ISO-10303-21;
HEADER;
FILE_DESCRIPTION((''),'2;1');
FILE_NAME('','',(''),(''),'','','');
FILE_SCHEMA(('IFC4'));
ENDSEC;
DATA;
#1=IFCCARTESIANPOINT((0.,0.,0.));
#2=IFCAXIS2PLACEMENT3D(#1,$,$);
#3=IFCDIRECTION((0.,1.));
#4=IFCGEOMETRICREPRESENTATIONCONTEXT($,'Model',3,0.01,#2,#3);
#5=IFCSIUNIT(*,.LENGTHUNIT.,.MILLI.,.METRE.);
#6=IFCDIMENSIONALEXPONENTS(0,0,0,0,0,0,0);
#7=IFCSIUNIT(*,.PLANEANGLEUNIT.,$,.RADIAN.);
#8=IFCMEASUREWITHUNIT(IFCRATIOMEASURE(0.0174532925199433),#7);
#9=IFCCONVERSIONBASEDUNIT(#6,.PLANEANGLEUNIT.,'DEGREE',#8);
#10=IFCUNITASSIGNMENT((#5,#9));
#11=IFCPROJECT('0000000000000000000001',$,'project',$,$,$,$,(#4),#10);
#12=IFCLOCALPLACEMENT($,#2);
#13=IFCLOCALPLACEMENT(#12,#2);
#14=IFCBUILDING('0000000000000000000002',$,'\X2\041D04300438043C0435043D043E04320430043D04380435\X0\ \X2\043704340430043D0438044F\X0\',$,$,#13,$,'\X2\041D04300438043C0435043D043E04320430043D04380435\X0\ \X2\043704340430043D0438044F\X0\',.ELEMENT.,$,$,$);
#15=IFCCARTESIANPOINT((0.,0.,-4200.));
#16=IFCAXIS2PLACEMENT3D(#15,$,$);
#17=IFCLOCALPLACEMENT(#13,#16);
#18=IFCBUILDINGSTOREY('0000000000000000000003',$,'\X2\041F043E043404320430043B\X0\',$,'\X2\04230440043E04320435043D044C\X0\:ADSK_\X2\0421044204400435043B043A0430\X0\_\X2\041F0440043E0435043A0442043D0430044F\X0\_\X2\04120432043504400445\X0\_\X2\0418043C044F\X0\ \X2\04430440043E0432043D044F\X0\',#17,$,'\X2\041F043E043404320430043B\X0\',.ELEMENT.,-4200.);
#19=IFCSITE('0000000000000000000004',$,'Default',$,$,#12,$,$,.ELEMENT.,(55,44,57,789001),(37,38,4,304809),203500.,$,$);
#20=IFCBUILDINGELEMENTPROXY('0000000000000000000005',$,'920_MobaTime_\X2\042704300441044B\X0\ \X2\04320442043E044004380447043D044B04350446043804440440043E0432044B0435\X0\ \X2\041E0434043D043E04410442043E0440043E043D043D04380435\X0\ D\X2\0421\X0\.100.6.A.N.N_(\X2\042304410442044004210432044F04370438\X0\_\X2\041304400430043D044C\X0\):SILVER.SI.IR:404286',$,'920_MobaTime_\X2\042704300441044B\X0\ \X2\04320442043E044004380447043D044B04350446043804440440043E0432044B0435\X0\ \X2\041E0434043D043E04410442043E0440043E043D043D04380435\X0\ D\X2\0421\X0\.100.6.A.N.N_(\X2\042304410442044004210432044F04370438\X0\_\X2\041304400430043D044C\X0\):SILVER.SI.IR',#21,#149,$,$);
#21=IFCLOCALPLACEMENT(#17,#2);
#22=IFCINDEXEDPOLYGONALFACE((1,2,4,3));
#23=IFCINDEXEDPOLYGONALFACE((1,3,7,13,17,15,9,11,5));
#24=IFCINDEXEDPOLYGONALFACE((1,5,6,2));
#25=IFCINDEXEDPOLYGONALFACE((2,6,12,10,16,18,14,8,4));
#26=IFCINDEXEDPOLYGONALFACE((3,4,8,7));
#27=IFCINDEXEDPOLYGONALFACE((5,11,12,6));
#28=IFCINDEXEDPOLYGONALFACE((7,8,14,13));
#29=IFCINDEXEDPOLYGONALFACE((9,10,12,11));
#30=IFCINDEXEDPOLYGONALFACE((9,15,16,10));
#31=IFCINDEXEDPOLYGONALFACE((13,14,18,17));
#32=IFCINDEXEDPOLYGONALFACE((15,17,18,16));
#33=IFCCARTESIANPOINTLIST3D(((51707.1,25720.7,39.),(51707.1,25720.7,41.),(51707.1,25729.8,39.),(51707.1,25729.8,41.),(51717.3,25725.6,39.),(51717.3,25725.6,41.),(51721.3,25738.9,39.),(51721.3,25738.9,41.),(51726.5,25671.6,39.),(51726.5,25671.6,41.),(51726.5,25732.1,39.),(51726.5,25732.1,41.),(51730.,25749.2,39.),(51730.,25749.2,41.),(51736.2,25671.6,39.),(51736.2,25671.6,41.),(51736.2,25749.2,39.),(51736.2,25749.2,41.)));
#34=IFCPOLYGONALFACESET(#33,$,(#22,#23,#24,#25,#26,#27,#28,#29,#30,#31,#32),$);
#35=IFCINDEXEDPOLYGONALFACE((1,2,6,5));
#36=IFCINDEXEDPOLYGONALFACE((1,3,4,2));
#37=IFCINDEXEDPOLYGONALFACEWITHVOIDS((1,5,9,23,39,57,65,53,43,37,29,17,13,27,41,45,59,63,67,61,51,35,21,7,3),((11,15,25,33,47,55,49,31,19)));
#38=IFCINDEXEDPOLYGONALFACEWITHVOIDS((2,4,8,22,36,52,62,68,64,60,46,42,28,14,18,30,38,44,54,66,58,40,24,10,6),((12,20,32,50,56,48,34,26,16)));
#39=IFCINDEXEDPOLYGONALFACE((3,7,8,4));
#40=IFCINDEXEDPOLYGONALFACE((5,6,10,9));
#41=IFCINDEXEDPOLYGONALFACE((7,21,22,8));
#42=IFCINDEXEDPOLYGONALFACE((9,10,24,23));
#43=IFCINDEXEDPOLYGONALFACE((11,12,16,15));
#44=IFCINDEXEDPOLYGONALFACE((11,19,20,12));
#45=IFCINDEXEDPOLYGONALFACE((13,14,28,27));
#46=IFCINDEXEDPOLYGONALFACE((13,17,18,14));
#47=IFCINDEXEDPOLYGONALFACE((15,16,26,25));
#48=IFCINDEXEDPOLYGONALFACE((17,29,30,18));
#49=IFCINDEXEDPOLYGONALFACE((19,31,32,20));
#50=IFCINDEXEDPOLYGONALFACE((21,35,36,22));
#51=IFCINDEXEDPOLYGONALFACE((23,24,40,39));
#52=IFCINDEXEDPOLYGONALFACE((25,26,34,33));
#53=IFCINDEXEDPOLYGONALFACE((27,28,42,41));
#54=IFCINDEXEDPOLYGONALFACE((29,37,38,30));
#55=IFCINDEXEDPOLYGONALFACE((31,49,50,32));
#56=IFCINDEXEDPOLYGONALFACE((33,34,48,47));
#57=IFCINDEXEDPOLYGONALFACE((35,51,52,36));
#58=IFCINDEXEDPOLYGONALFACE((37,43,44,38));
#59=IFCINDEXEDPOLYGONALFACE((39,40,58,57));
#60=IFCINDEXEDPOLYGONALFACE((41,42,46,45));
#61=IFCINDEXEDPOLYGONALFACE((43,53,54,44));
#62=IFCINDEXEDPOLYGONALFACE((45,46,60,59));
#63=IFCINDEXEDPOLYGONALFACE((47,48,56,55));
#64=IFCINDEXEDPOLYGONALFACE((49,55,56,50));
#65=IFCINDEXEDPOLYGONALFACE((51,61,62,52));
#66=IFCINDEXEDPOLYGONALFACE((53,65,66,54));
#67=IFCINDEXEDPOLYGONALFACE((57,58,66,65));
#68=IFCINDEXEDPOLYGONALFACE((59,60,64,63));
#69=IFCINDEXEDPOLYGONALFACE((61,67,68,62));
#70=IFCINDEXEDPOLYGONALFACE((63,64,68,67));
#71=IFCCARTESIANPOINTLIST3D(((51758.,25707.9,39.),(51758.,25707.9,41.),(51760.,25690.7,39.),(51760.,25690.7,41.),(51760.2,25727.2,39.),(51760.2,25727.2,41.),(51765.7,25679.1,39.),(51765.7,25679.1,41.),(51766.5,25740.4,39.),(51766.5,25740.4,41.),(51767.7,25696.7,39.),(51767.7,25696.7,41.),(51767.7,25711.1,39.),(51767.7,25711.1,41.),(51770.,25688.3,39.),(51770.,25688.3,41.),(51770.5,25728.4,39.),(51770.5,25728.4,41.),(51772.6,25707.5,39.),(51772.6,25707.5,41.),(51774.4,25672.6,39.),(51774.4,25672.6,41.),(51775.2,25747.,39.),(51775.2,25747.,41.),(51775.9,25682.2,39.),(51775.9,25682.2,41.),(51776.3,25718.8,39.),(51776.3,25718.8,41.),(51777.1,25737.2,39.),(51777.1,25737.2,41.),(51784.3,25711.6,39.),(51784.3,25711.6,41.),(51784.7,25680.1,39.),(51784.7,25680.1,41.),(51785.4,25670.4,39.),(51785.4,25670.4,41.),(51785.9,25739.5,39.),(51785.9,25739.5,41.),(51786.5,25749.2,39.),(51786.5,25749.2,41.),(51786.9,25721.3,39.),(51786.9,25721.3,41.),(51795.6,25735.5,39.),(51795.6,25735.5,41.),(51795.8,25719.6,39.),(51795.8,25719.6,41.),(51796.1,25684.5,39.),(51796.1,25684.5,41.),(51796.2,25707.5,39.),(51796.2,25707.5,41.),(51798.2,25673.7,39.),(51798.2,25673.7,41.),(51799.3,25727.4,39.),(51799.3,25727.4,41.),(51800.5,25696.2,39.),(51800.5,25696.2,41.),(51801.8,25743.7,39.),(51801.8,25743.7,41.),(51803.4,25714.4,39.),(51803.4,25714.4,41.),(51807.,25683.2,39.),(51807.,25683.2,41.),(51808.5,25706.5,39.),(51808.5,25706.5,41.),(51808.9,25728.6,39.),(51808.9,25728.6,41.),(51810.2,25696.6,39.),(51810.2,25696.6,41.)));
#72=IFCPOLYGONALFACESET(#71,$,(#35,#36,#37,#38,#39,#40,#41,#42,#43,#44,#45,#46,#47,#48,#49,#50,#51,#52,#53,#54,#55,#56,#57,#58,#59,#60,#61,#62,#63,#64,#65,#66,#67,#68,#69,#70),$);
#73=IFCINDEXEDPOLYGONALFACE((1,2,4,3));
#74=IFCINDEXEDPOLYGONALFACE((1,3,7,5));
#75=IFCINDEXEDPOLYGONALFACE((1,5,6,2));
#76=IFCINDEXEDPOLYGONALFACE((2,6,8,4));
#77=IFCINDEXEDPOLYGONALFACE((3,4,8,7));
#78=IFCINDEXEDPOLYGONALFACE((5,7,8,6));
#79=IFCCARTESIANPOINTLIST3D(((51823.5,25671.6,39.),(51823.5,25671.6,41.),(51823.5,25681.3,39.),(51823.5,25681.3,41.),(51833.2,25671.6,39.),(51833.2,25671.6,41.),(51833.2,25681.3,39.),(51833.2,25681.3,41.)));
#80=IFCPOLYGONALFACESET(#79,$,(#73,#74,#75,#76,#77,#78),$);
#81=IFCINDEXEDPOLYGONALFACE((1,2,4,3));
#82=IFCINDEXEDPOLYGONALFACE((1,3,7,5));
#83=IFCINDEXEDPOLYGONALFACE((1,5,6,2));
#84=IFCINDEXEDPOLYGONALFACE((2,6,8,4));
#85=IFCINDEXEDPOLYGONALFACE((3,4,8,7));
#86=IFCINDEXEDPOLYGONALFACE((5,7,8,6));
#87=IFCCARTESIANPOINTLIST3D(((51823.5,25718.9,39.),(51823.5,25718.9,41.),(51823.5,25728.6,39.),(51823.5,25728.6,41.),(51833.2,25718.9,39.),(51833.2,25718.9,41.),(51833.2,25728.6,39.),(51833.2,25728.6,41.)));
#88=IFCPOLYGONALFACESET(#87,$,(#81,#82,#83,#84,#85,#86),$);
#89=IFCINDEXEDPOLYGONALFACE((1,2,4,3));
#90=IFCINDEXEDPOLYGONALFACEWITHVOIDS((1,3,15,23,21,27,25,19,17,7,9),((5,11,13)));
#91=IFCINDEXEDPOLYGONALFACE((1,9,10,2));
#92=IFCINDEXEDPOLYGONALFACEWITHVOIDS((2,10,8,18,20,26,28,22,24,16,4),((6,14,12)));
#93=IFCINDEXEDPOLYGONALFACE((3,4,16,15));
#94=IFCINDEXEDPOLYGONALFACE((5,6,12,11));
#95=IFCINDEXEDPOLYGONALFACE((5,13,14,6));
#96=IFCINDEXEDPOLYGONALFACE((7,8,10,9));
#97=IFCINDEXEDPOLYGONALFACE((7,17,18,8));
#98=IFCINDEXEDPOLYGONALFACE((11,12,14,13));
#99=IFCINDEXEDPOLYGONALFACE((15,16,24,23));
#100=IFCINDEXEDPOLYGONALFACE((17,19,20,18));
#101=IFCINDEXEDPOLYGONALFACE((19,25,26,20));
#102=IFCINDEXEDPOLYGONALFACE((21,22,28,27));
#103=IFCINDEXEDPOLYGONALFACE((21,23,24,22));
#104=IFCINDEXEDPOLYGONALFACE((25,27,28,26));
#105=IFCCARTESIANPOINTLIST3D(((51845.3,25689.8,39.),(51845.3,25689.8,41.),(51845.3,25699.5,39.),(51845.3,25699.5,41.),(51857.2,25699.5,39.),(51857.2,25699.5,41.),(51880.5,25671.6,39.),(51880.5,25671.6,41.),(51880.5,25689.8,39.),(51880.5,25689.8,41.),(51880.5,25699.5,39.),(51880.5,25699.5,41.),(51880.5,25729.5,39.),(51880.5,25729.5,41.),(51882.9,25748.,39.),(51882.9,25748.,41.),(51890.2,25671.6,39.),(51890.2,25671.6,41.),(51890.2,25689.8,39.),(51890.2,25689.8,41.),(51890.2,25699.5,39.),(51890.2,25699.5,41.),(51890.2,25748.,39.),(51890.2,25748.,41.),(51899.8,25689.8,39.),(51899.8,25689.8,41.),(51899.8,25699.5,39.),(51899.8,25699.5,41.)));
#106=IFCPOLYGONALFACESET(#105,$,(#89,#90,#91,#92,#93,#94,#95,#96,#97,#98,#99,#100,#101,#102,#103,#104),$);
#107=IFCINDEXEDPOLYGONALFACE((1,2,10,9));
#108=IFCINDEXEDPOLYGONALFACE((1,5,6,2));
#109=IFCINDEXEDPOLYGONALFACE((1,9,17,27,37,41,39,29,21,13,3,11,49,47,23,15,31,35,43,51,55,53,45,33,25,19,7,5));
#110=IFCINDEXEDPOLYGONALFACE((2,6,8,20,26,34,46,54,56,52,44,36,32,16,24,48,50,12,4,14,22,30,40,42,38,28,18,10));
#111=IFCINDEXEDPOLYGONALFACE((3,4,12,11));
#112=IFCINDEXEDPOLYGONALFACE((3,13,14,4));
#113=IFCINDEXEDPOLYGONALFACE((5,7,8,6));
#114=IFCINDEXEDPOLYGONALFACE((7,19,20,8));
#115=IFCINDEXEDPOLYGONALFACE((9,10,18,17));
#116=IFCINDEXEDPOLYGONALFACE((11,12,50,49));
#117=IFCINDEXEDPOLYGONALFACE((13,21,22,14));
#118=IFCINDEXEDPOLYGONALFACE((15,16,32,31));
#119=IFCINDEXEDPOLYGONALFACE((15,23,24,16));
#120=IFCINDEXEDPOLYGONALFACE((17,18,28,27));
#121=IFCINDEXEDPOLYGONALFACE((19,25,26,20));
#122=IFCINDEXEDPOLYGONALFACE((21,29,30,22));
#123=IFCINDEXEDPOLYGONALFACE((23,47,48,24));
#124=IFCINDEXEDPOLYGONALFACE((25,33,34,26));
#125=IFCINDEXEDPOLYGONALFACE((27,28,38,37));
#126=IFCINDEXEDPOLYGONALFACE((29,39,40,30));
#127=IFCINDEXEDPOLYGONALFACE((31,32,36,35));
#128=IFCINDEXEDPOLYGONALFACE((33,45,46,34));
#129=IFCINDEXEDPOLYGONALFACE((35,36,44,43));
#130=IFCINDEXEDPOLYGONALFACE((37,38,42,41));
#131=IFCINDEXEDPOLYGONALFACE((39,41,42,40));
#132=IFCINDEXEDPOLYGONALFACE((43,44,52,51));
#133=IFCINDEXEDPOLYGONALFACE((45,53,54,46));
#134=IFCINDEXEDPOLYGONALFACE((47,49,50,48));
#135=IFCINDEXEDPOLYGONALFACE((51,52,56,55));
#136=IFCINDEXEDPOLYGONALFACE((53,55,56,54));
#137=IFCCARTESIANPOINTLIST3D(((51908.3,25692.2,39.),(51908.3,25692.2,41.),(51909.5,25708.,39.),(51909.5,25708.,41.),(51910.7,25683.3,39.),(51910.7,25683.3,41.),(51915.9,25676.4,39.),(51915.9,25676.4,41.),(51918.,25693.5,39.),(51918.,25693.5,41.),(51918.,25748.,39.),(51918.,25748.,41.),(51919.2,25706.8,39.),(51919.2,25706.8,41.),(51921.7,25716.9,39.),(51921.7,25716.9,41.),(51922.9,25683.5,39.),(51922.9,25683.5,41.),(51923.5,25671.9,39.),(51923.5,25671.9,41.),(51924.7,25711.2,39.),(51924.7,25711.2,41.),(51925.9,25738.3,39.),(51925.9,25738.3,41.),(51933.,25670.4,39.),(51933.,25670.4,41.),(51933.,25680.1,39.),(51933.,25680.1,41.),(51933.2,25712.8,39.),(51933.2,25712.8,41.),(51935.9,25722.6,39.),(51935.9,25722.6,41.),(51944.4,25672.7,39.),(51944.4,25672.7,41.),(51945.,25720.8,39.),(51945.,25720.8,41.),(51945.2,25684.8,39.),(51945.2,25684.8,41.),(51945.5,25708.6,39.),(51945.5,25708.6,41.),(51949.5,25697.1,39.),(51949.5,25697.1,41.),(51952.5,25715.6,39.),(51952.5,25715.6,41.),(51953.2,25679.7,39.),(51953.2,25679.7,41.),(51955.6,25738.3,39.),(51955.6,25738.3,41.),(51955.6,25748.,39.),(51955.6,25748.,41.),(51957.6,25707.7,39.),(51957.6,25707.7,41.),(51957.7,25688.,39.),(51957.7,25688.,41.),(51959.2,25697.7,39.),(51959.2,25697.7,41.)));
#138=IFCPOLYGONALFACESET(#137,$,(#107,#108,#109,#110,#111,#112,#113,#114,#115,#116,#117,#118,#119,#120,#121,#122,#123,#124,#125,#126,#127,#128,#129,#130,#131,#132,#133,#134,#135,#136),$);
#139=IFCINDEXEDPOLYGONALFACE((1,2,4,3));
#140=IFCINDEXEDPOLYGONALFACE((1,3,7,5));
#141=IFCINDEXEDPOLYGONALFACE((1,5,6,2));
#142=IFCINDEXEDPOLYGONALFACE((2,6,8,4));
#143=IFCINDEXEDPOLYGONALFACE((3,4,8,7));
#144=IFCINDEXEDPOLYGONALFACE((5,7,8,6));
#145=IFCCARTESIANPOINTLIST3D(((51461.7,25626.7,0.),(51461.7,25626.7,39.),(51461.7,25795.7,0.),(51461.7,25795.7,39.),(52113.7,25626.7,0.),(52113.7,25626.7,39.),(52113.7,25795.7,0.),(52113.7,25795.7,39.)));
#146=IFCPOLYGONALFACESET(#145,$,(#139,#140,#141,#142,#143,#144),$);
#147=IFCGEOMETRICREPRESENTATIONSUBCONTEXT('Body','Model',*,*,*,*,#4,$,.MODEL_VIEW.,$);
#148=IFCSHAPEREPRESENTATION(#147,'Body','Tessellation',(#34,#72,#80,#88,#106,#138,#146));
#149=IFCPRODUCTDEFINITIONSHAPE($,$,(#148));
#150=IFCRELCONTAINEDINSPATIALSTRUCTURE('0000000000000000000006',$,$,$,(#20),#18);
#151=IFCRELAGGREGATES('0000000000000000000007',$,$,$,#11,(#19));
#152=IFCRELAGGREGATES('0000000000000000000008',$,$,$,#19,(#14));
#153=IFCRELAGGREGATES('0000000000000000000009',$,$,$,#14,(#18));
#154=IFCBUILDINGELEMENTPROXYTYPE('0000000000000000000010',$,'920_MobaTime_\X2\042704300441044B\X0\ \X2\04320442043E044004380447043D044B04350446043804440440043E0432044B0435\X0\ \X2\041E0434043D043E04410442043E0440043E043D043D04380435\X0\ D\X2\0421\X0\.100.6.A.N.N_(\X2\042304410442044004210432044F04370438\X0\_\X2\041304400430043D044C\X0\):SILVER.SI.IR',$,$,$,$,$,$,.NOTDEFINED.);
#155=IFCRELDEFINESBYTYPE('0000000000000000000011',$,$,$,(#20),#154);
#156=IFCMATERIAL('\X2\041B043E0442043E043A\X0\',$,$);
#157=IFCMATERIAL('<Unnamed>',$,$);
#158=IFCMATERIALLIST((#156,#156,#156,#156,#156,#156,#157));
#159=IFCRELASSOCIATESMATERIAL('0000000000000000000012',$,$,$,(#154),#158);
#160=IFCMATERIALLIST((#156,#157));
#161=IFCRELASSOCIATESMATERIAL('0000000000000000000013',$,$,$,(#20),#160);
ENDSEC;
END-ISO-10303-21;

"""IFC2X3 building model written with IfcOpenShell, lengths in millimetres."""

from ifc_helpers import new_model, entity, si_unit, converted_unit, direction, frame, origin, origin_2d_with_axis, place, context, subcontext, project, spatial, polyline, rectangle, outline, extrude, source, transform, mapped, material, material_list, type_object, type_shapes, element, save


model = new_model("IFC2X3")

# Units and contexts
model_context = context("Model", 3, precision=0.01, world=origin(), true_north=direction((0.0, 1.0)))
body_context = subcontext(model_context, "Body", "Model", "MODEL_VIEW")
ifc_project = project(units=[si_unit("LENGTHUNIT", "METRE", prefix="MILLI"), converted_unit("PLANEANGLEUNIT", "DEGREE", entity("IfcRatioMeasure", 0.0174532925199433), si_unit("PLANEANGLEUNIT", "RADIAN"), dimensions=[0, 0, 0, 0, 0, 0, 0])], contexts=[model_context])

# Site, building, storey
site_placement = place(None, origin())
site = spatial("IfcSite", under=ifc_project, at=site_placement, Name="Default", CompositionType="ELEMENT", RefLatitude=(55, 44, 57, 789001), RefLongitude=(37, 38, 4, 304809), RefElevation=203500.0)
building_placement = place(site_placement, origin())
building = spatial("IfcBuilding", under=site, at=building_placement, Name="Наименование здания", LongName="Наименование здания", CompositionType="ELEMENT")
storey_placement = place(building_placement, frame((0.0, 0.0, -4200.0)))
storey = spatial("IfcBuildingStorey", under=building, at=storey_placement, Name="Подвал", ObjectType="Уровень:ADSK_Стрелка_Проектная_Вверх_Имя уровня", LongName="Подвал", CompositionType="ELEMENT", Elevation=-4200.0)

# Building element proxy
ifc_material_1 = material(Name="Лоток")
ifc_material_2 = material(Name="<Unnamed>")
ifc_material_list_1 = material_list([ifc_material_1, ifc_material_2])
ifc_material_list_2 = material_list([ifc_material_1, ifc_material_1, ifc_material_1, ifc_material_1, ifc_material_1, ifc_material_1, ifc_material_2])
building_element_proxy_type = type_object("IfcBuildingElementProxyType", Name="920_MobaTime_Часы вторичныецифровые Односторонние DС.100.6.A.N.N_(УстрСвязи_Грань):SILVER.SI.IR", PredefinedType="NOTDEFINED", material=ifc_material_list_2)
shared_shape = source(origin(), body_context, "Body", "SweptSolid", [
    extrude(outline(polyline([(-49.3, -13.1), (28.2, -13.1), (28.2, -6.8), (17.9, 1.8), (8.8, 16.0), (-0.3, 16.0), (4.6, 5.8), (11.1, -3.4), (-49.3, -3.4), (-49.3, -13.1)])), frame((-64.6, 9.8, 39.0), z_axis=(0.0, 0.0, 1.0), x_axis=(0.0, 1.0, 0.0)), (0.0, 0.0, 1.0), 2.0),
    extrude(outline(polyline([(2.2, -27.6), (19.0, -27.6), (30.5, -16.1), (33.3, -4.9), (31.0, 5.8), (21.8, 17.2), (5.2, 27.3), (-11.1, 33.0), (-24.0, 32.7), (-33.6, 27.6), (-40.3, 18.6), (-42.8, 5.7), (-38.0, -6.3), (-27.2, -14.9), (-17.5, -17.7), (-8.2, -16.4), (-0.3, -11.9), (5.1, -4.5), (7.3, 6.2), (4.0, 17.2), (18.4, 7.3), (23.6, -2.4), (22.0, -11.4), (14.2, -18.4), (5.3, -18.3), (2.2, -27.6)]), holes=[polyline([(-9.0, 23.3), (-1.3, 14.3), (-2.5, 2.0), (-11.4, -7.0), (-23.4, -6.0), (-32.2, 2.9), (-31.2, 15.1), (-25.6, 22.1), (-17.5, 24.9), (-9.0, 23.3)])]), frame((-2.7, 3.6, 39.0), z_axis=(0.0, 0.0, 1.0), x_axis=(-0.427649, 0.903945, 0.0)), (0.0, 0.0, 1.0), 2.0),
    extrude(rectangle(XDim=9.7, YDim=9.7, at=origin_2d_with_axis()), frame((40.6, -34.7, 39.0)), (0.0, 0.0, 1.0), 2.0),
    extrude(rectangle(XDim=9.7, YDim=9.7, at=origin_2d_with_axis()), frame((40.6, 12.6, 39.0)), (0.0, 0.0, 1.0), 2.0),
    extrude(outline(polyline([(-0.9, -28.1), (8.8, -28.1), (8.8, -9.9), (18.5, -9.9), (18.5, -0.2), (8.8, -0.2), (8.8, 48.3), (1.5, 48.3), (-36.0, -0.2), (-36.0, -9.9), (-0.9, -9.9), (-0.9, -28.1)]), holes=[polyline([(-0.9, -0.2), (-24.1, -0.2), (-0.9, 29.7), (-0.9, -0.2)])]), frame((93.6, -11.4, 39.0)), (0.0, 0.0, 1.0), 2.0),
    extrude(outline(polyline([(3.3, -28.3), (12.5, -28.3), (20.5, -25.0), (26.8, -18.9), (30.7, -10.0), (31.4, 1.6), (26.9, 11.8), (20.1, 18.4), (11.1, 22.3), (1.0, 23.3), (-7.9, 20.4), (-14.9, 14.5), (-18.9, 6.2), (-17.1, -9.0), (-36.7, 0.5), (-29.1, 29.2), (-38.5, 31.7), (-48.1, -4.6), (-11.6, -23.1), (-8.0, -14.0), (-10.8, -7.6), (-10.2, 1.1), (-3.0, 11.8), (9.2, 12.8), (20.0, 5.5), (21.4, -7.5), (15.5, -16.4), (4.6, -18.6), (3.3, -28.3)])), frame((147.1, -8.5, 39.0), z_axis=(0.0, 0.0, 1.0), x_axis=(0.256974, -0.966418, 0.0)), (0.0, 0.0, 1.0), 2.0),
    extrude(rectangle(XDim=652.0, YDim=169.0, at=origin_2d_with_axis()), frame((0.0, 0.0, 0.0), z_axis=(0.0, 0.0, 1.0), x_axis=(-1.0, 0.0, 0.0)), (0.0, 0.0, 1.0), 39.0),
])
type_shapes(building_element_proxy_type, [shared_shape])
proxy_placement = place(storey_placement, frame((51787.7, 25711.2, 0.0)))
element("IfcBuildingElementProxy", 1, at=proxy_placement, inside=storey, type_object=building_element_proxy_type, material=ifc_material_list_1, Name="920_MobaTime_Часы вторичныецифровые Односторонние DС.100.6.A.N.N_(УстрСвязи_Грань):SILVER.SI.IR:404286", ObjectType="920_MobaTime_Часы вторичныецифровые Односторонние DС.100.6.A.N.N_(УстрСвязи_Грань):SILVER.SI.IR", context=body_context, shape_type="MappedRepresentation", body=[
    mapped(shared_shape, transform((0.0, 0.0, 0.0), scale=1.0)),
])

save(model, "model.ifc")
